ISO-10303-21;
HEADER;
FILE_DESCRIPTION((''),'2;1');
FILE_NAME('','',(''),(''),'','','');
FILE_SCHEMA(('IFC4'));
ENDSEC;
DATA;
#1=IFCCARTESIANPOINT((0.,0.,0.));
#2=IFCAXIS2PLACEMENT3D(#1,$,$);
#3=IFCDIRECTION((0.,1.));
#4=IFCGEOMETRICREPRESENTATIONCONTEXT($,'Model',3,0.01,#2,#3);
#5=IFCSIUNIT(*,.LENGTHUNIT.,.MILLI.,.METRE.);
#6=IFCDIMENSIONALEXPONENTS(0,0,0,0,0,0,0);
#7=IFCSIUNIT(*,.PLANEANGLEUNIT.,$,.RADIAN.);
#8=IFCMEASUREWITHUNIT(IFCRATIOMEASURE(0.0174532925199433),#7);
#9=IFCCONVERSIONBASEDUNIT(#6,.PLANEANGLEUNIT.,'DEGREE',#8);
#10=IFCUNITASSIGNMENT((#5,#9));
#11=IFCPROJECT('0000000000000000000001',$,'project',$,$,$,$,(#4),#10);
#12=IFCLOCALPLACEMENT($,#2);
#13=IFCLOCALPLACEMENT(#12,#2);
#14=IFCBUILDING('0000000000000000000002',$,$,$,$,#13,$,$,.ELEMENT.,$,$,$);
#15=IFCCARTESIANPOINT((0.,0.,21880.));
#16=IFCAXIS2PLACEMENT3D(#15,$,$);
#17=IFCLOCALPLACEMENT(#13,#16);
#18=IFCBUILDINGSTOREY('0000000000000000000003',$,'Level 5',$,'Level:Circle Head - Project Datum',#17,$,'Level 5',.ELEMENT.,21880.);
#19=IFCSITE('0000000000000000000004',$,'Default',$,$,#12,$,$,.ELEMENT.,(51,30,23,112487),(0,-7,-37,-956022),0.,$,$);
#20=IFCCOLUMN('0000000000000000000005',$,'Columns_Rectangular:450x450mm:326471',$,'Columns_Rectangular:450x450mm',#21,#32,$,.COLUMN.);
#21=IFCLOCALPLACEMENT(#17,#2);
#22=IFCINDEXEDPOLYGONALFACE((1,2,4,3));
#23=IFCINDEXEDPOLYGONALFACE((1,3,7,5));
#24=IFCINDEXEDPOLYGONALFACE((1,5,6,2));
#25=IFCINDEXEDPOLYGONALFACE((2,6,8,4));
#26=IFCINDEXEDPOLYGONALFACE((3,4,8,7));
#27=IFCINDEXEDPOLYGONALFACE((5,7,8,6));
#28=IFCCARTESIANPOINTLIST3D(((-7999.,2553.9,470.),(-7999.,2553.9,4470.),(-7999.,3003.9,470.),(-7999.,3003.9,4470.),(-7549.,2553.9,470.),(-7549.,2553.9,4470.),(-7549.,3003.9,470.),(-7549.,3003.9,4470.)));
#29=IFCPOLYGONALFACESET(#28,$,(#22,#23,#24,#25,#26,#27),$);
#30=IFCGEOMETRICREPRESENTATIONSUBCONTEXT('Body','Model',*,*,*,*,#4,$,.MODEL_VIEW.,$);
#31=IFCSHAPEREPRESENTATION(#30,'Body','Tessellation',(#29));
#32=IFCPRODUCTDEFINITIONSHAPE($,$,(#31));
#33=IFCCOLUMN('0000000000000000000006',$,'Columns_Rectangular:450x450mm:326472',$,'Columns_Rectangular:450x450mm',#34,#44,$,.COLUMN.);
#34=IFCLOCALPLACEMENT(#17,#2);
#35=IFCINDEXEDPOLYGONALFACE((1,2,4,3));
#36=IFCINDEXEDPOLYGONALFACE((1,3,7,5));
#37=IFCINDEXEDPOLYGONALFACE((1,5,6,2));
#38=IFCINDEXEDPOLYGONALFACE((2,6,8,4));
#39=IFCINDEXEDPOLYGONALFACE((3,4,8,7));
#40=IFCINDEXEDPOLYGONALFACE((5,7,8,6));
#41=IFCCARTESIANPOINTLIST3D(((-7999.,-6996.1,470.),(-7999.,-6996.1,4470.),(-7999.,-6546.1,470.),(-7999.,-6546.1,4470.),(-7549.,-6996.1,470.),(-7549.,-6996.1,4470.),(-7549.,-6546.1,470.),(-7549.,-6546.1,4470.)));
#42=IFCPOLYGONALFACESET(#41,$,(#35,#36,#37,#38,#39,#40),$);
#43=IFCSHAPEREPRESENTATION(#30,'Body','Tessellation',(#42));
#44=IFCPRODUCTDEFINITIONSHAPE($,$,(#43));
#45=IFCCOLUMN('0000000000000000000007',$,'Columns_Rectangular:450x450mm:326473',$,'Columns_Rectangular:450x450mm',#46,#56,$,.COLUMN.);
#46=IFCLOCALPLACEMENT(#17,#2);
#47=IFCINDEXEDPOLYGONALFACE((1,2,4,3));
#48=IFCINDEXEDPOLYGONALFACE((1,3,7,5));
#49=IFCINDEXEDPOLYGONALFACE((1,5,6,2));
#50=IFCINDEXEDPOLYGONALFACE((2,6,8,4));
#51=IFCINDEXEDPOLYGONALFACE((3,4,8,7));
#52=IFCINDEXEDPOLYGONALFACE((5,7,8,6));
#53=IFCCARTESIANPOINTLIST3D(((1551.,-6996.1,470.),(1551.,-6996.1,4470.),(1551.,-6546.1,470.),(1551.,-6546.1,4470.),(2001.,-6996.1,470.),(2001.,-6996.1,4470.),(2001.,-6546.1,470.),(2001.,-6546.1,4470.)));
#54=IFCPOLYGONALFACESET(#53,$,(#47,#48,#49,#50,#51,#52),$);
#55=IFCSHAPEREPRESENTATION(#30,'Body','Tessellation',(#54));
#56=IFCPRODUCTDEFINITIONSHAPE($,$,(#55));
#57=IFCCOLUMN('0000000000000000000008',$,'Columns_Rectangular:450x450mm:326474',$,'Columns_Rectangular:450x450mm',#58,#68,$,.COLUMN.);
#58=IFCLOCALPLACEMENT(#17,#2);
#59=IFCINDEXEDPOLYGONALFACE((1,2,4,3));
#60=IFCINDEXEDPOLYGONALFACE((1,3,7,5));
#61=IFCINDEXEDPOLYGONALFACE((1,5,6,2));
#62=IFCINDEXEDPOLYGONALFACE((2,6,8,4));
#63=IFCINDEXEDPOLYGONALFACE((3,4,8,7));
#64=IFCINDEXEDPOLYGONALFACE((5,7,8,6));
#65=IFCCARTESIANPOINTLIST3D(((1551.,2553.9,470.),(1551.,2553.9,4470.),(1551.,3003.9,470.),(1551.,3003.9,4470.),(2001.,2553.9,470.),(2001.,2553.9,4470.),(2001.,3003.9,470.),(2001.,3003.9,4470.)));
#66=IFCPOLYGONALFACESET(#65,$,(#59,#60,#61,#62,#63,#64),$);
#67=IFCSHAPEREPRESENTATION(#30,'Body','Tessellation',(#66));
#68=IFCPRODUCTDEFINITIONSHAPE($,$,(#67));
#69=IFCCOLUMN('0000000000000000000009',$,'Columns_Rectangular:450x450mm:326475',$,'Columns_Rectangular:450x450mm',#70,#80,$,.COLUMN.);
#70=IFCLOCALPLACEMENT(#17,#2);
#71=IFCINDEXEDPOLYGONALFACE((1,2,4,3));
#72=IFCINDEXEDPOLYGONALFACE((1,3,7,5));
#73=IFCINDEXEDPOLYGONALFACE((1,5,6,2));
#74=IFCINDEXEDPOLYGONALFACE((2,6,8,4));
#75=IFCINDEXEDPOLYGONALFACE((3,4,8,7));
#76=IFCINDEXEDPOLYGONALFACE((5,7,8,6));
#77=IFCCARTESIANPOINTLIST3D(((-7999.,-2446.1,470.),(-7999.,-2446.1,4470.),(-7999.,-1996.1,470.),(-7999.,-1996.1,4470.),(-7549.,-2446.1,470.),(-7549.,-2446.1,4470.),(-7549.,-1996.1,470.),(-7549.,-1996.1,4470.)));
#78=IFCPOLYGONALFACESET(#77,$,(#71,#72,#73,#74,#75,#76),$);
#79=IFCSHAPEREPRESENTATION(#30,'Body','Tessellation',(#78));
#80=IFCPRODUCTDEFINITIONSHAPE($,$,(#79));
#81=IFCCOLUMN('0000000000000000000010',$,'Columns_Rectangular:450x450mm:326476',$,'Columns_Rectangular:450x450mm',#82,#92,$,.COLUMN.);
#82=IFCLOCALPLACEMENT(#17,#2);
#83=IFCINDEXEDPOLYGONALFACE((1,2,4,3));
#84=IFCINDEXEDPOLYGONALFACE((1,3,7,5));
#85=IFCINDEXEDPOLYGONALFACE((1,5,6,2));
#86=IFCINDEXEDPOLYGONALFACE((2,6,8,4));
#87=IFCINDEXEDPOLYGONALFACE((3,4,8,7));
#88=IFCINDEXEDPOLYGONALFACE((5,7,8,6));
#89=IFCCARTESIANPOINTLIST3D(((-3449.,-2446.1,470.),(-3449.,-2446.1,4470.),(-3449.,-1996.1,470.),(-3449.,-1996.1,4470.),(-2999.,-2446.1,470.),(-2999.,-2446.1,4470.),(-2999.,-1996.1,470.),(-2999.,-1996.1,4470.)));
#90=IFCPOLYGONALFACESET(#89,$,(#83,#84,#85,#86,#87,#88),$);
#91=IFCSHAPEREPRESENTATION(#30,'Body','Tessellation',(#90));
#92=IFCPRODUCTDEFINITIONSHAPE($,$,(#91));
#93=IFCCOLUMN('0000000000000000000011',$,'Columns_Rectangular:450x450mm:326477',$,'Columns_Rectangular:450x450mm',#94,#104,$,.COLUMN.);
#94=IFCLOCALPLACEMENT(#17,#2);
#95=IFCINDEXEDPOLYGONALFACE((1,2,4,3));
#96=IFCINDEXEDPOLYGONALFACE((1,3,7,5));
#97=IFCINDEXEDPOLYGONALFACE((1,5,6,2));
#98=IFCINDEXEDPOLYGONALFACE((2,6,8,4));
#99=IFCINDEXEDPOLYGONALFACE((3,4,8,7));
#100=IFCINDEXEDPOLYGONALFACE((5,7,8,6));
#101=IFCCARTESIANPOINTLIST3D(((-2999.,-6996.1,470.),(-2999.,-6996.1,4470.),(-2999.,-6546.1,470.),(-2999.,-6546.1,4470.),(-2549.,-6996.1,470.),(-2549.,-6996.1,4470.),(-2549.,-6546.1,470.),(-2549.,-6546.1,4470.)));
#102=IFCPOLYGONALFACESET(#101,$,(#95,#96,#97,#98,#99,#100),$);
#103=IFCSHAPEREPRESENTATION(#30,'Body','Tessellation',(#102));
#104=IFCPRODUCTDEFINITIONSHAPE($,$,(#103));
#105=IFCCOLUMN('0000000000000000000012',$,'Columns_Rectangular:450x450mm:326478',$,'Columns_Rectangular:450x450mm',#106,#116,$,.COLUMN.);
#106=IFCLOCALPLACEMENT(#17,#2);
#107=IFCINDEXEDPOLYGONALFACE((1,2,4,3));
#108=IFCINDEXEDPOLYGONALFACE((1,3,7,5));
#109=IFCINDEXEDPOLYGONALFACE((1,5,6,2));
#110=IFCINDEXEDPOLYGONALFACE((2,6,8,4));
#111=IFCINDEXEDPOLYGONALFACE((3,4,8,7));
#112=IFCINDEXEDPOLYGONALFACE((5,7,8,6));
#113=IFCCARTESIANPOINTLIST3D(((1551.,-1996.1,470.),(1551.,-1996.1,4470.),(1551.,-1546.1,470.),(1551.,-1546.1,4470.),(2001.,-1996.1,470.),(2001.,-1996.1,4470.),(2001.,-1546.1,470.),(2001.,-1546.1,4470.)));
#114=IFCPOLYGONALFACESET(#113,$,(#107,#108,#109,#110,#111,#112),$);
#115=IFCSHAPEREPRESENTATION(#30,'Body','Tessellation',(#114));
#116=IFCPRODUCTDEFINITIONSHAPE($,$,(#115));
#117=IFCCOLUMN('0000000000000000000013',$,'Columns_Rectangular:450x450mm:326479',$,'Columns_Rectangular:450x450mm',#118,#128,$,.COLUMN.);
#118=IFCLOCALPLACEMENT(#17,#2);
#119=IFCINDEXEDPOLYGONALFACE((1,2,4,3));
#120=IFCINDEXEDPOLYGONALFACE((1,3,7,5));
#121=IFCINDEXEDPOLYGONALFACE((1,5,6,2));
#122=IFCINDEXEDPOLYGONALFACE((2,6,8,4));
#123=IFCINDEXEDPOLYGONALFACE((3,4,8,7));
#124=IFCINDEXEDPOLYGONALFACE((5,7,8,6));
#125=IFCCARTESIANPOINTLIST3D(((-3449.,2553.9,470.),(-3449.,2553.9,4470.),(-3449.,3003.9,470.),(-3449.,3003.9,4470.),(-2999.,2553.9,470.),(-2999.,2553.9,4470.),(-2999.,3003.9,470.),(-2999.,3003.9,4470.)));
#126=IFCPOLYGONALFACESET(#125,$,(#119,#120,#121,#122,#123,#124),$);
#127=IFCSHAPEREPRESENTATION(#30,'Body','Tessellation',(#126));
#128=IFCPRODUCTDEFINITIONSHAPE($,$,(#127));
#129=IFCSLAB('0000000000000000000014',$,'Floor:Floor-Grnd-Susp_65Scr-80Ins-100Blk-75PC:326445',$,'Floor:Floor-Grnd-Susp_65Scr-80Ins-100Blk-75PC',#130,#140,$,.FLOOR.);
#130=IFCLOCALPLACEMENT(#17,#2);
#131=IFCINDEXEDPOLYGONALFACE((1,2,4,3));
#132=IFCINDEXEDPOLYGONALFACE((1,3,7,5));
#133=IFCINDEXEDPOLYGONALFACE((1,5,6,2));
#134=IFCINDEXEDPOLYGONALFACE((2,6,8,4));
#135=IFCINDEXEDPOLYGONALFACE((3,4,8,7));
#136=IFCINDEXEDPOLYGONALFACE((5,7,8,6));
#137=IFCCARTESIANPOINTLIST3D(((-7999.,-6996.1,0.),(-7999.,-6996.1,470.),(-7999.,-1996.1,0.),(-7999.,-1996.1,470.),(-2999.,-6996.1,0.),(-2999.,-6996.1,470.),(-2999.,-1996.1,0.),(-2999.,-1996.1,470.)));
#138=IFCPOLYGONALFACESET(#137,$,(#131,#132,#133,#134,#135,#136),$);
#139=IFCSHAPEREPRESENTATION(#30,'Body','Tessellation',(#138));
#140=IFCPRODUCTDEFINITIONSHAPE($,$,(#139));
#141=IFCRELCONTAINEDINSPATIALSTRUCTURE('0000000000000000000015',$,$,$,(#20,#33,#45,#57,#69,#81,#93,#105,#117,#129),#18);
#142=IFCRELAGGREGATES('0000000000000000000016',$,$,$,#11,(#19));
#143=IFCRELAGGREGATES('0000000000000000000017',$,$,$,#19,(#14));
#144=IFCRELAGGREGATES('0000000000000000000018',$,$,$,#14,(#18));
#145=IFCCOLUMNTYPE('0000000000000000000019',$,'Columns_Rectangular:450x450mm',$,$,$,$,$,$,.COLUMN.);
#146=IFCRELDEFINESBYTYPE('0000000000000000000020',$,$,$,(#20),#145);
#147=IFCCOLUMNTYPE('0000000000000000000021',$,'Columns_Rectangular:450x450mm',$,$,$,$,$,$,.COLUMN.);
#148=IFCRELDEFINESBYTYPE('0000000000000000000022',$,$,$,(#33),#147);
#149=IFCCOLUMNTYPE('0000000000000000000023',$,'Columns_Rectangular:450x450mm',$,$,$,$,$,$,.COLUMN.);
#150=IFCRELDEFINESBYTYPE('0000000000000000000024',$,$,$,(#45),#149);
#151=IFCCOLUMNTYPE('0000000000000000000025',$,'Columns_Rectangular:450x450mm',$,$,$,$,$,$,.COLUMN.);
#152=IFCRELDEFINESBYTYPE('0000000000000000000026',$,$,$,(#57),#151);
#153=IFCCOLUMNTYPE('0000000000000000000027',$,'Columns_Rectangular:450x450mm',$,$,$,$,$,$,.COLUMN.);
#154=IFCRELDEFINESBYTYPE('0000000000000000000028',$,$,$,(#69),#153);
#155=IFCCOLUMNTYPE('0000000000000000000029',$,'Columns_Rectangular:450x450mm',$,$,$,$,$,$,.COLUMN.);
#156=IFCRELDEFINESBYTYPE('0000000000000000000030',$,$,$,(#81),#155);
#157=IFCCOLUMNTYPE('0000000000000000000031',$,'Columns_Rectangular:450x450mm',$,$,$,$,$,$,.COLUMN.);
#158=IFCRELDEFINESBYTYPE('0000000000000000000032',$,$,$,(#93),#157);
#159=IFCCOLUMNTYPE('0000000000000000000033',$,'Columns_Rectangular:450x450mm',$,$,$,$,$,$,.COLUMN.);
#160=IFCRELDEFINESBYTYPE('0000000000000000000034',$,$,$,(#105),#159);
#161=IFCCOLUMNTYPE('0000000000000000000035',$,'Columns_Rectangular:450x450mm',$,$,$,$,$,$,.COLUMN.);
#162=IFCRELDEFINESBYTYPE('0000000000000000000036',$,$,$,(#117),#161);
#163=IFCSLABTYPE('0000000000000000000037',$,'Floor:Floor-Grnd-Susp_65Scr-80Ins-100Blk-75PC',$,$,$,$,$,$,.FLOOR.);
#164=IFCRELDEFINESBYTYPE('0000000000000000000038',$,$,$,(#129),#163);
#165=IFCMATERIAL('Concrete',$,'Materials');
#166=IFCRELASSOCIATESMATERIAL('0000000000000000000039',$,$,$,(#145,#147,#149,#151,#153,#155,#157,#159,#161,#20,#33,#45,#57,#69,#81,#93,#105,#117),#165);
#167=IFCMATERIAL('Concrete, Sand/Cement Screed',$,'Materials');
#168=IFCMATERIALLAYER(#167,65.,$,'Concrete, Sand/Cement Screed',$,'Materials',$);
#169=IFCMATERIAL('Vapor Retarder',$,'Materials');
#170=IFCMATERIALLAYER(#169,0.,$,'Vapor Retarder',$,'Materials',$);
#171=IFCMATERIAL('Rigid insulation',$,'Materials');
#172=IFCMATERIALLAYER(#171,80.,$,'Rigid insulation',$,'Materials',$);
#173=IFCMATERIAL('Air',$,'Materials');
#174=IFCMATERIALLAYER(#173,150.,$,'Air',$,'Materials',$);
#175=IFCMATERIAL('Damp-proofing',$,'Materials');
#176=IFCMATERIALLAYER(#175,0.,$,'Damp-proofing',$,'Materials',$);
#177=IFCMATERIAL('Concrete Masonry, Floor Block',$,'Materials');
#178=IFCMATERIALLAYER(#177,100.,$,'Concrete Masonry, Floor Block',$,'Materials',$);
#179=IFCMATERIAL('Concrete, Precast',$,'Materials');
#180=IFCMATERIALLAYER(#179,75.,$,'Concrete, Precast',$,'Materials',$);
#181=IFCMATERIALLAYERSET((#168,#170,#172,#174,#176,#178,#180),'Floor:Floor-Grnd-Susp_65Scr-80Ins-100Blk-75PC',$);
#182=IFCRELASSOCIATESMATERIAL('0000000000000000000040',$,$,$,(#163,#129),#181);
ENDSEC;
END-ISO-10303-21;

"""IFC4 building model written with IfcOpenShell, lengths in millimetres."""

from ifc_helpers import new_model, entity, si_unit, converted_unit, direction, frame, frame_2d, origin, origin_2d_with_axis, place, context, subcontext, project, spatial, polyline, segment, composite_curve, rectangle, outline, extrude, source, transform, mapped, material, layer, layer_set, layer_usage, material_profile, profile_set, profile_usage, type_object, type_shapes, element, save


model = new_model("IFC4")

# Units and contexts
model_context = context("Model", 3, precision=0.01, world=origin(), true_north=direction((0.0, 1.0)))
body_context = subcontext(model_context, "Body", "Model", "MODEL_VIEW")
ifc_project = project(units=[si_unit("LENGTHUNIT", "METRE", prefix="MILLI"), converted_unit("PLANEANGLEUNIT", "DEGREE", entity("IfcRatioMeasure", 0.0174532925199433), si_unit("PLANEANGLEUNIT", "RADIAN"), dimensions=[0, 0, 0, 0, 0, 0, 0])], contexts=[model_context])

# Site, building, storey
site_placement = place(None, origin())
site = spatial("IfcSite", under=ifc_project, at=site_placement, Name="Default", CompositionType="ELEMENT", RefLatitude=(51, 30, 23, 112487), RefLongitude=(0, -7, -37, -956022), RefElevation=0.0)
building_placement = place(site_placement, origin())
building = spatial("IfcBuilding", under=site, at=building_placement, CompositionType="ELEMENT")
storey_placement = place(building_placement, frame((0.0, 0.0, 21880.0)))
storey = spatial("IfcBuildingStorey", under=building, at=storey_placement, Name="Level 5", ObjectType="Level:Circle Head - Project Datum", LongName="Level 5", CompositionType="ELEMENT", Elevation=21880.0)

# Columns
ifc_material_1 = material(Name="Concrete", Category="Materials")
ifc_material_profile = material_profile(ifc_material_1, outline(composite_curve([segment(polyline([(225.0, 225.0, 0.0), (225.0, -225.0, 0.0)]), True, "CONTINUOUS"), segment(polyline([(225.0, -225.0, 0.0), (-225.0, -225.0, 0.0)]), True, "CONTINUOUS"), segment(polyline([(-225.0, -225.0, 0.0), (-225.0, 225.0, 0.0)]), True, "CONTINUOUS"), segment(polyline([(-225.0, 225.0, 0.0), (225.0, 225.0, 0.0)]), True, "CONTINUOUS")], self_intersect=False), kind="CURVE"), Name="450x450mm")
ifc_profile_set = profile_set([ifc_material_profile], Name="450x450mm")
ifc_profile_usage_1 = profile_usage(ifc_profile_set)
column_type_1 = type_object("IfcColumnType", Name="Columns_Rectangular:450x450mm", PredefinedType="COLUMN", material=ifc_profile_set)
shared_shape_1 = source(origin(), body_context, "Body", "SweptSolid", [
    extrude(rectangle(XDim=450.0, YDim=450.0, at=frame_2d((0.0, 0.0), x_axis=(1.0, 0.0))), frame((-7774.0, 2778.9, 22350.0), z_axis=(0.0, 0.0, 1.0), x_axis=(0.0, -1.0, 0.0)), (0.0, 0.0, 1.0), 4000.0),
])
type_shapes(column_type_1, [shared_shape_1])
column_1_placement = place(storey_placement, frame((0.0, 0.0, -21880.0)))
element("IfcColumn", 1, at=column_1_placement, inside=storey, type_object=column_type_1, material=ifc_profile_usage_1, Name="Columns_Rectangular:450x450mm:326471", ObjectType="Columns_Rectangular:450x450mm", PredefinedType="COLUMN", context=body_context, shape_type="MappedRepresentation", body=[
    mapped(shared_shape_1, transform((0.0, 0.0, 0.0), scale=1.0)),
])
ifc_profile_usage_2 = profile_usage(ifc_profile_set)
column_type_2 = type_object("IfcColumnType", Name="Columns_Rectangular:450x450mm", PredefinedType="COLUMN", material=ifc_profile_set)
shared_shape_2 = source(origin(), body_context, "Body", "SweptSolid", [
    extrude(rectangle(XDim=450.0, YDim=450.0, at=frame_2d((0.0, 0.0), x_axis=(1.0, 0.0))), frame((-7774.0, -6771.1, 22350.0), z_axis=(0.0, 0.0, 1.0), x_axis=(0.0, -1.0, 0.0)), (0.0, 0.0, 1.0), 4000.0),
])
type_shapes(column_type_2, [shared_shape_2])
column_2_placement = place(storey_placement, frame((0.0, 0.0, -21880.0)))
element("IfcColumn", 2, at=column_2_placement, inside=storey, type_object=column_type_2, material=ifc_profile_usage_2, Name="Columns_Rectangular:450x450mm:326472", ObjectType="Columns_Rectangular:450x450mm", PredefinedType="COLUMN", context=body_context, shape_type="MappedRepresentation", body=[
    mapped(shared_shape_2, transform((0.0, 0.0, 0.0), scale=1.0)),
])
ifc_profile_usage_3 = profile_usage(ifc_profile_set)
column_type_3 = type_object("IfcColumnType", Name="Columns_Rectangular:450x450mm", PredefinedType="COLUMN", material=ifc_profile_set)
shared_shape_3 = source(origin(), body_context, "Body", "SweptSolid", [
    extrude(rectangle(XDim=450.0, YDim=450.0, at=frame_2d((0.0, 0.0), x_axis=(1.0, 0.0))), frame((1776.0, -6771.1, 22350.0), z_axis=(0.0, 0.0, 1.0), x_axis=(0.0, -1.0, 0.0)), (0.0, 0.0, 1.0), 4000.0),
])
type_shapes(column_type_3, [shared_shape_3])
column_3_placement = place(storey_placement, frame((0.0, 0.0, -21880.0)))
element("IfcColumn", 3, at=column_3_placement, inside=storey, type_object=column_type_3, material=ifc_profile_usage_3, Name="Columns_Rectangular:450x450mm:326473", ObjectType="Columns_Rectangular:450x450mm", PredefinedType="COLUMN", context=body_context, shape_type="MappedRepresentation", body=[
    mapped(shared_shape_3, transform((0.0, 0.0, 0.0), scale=1.0)),
])
ifc_profile_usage_4 = profile_usage(ifc_profile_set)
column_type_4 = type_object("IfcColumnType", Name="Columns_Rectangular:450x450mm", PredefinedType="COLUMN", material=ifc_profile_set)
shared_shape_4 = source(origin(), body_context, "Body", "SweptSolid", [
    extrude(rectangle(XDim=450.0, YDim=450.0, at=frame_2d((0.0, 0.0), x_axis=(1.0, 0.0))), frame((1776.0, 2778.9, 22350.0), z_axis=(0.0, 0.0, 1.0), x_axis=(0.0, -1.0, 0.0)), (0.0, 0.0, 1.0), 4000.0),
])
type_shapes(column_type_4, [shared_shape_4])
column_4_placement = place(storey_placement, frame((0.0, 0.0, -21880.0)))
element("IfcColumn", 4, at=column_4_placement, inside=storey, type_object=column_type_4, material=ifc_profile_usage_4, Name="Columns_Rectangular:450x450mm:326474", ObjectType="Columns_Rectangular:450x450mm", PredefinedType="COLUMN", context=body_context, shape_type="MappedRepresentation", body=[
    mapped(shared_shape_4, transform((0.0, 0.0, 0.0), scale=1.0)),
])
ifc_profile_usage_5 = profile_usage(ifc_profile_set)
column_type_5 = type_object("IfcColumnType", Name="Columns_Rectangular:450x450mm", PredefinedType="COLUMN", material=ifc_profile_set)
shared_shape_5 = source(origin(), body_context, "Body", "SweptSolid", [
    extrude(rectangle(XDim=450.0, YDim=450.0, at=frame_2d((0.0, 0.0), x_axis=(1.0, 0.0))), frame((-7774.0, -2221.1, 22350.0), z_axis=(0.0, 0.0, 1.0), x_axis=(0.0, -1.0, 0.0)), (0.0, 0.0, 1.0), 4000.0),
])
type_shapes(column_type_5, [shared_shape_5])
column_5_placement = place(storey_placement, frame((0.0, 0.0, -21880.0)))
element("IfcColumn", 5, at=column_5_placement, inside=storey, type_object=column_type_5, material=ifc_profile_usage_5, Name="Columns_Rectangular:450x450mm:326475", ObjectType="Columns_Rectangular:450x450mm", PredefinedType="COLUMN", context=body_context, shape_type="MappedRepresentation", body=[
    mapped(shared_shape_5, transform((0.0, 0.0, 0.0), scale=1.0)),
])
ifc_profile_usage_6 = profile_usage(ifc_profile_set)
column_type_6 = type_object("IfcColumnType", Name="Columns_Rectangular:450x450mm", PredefinedType="COLUMN", material=ifc_profile_set)
shared_shape_6 = source(origin(), body_context, "Body", "SweptSolid", [
    extrude(rectangle(XDim=450.0, YDim=450.0, at=origin_2d_with_axis()), frame((0.0, 0.0, 22350.0), z_axis=(0.0, 0.0, 1.0), x_axis=(0.0, -1.0, 0.0)), (0.0, 0.0, 1.0), 4000.0),
])
type_shapes(column_type_6, [shared_shape_6])
column_6_placement = place(storey_placement, frame((-3224.0, -2221.1, -21880.0)))
element("IfcColumn", 6, at=column_6_placement, inside=storey, type_object=column_type_6, material=ifc_profile_usage_6, Name="Columns_Rectangular:450x450mm:326476", ObjectType="Columns_Rectangular:450x450mm", PredefinedType="COLUMN", context=body_context, shape_type="MappedRepresentation", body=[
    mapped(shared_shape_6, transform((0.0, 0.0, 0.0), scale=1.0)),
])
ifc_profile_usage_7 = profile_usage(ifc_profile_set)
column_type_7 = type_object("IfcColumnType", Name="Columns_Rectangular:450x450mm", PredefinedType="COLUMN", material=ifc_profile_set)
shared_shape_7 = source(origin(), body_context, "Body", "SweptSolid", [
    extrude(rectangle(XDim=450.0, YDim=450.0, at=frame_2d((0.0, 0.0), x_axis=(1.0, 0.0))), frame((-2774.0, -6771.1, 22350.0), z_axis=(0.0, 0.0, 1.0), x_axis=(0.0, -1.0, 0.0)), (0.0, 0.0, 1.0), 4000.0),
])
type_shapes(column_type_7, [shared_shape_7])
column_7_placement = place(storey_placement, frame((0.0, 0.0, -21880.0)))
element("IfcColumn", 7, at=column_7_placement, inside=storey, type_object=column_type_7, material=ifc_profile_usage_7, Name="Columns_Rectangular:450x450mm:326477", ObjectType="Columns_Rectangular:450x450mm", PredefinedType="COLUMN", context=body_context, shape_type="MappedRepresentation", body=[
    mapped(shared_shape_7, transform((0.0, 0.0, 0.0), scale=1.0)),
])
ifc_profile_usage_8 = profile_usage(ifc_profile_set)
column_type_8 = type_object("IfcColumnType", Name="Columns_Rectangular:450x450mm", PredefinedType="COLUMN", material=ifc_profile_set)
shared_shape_8 = source(origin(), body_context, "Body", "SweptSolid", [
    extrude(rectangle(XDim=450.0, YDim=450.0, at=frame_2d((0.0, 0.0), x_axis=(1.0, 0.0))), frame((1776.0, -1771.1, 22350.0), z_axis=(0.0, 0.0, 1.0), x_axis=(0.0, -1.0, 0.0)), (0.0, 0.0, 1.0), 4000.0),
])
type_shapes(column_type_8, [shared_shape_8])
column_8_placement = place(storey_placement, frame((0.0, 0.0, -21880.0)))
element("IfcColumn", 8, at=column_8_placement, inside=storey, type_object=column_type_8, material=ifc_profile_usage_8, Name="Columns_Rectangular:450x450mm:326478", ObjectType="Columns_Rectangular:450x450mm", PredefinedType="COLUMN", context=body_context, shape_type="MappedRepresentation", body=[
    mapped(shared_shape_8, transform((0.0, 0.0, 0.0), scale=1.0)),
])
ifc_profile_usage_9 = profile_usage(ifc_profile_set)
column_type_9 = type_object("IfcColumnType", Name="Columns_Rectangular:450x450mm", PredefinedType="COLUMN", material=ifc_profile_set)
shared_shape_9 = source(origin(), body_context, "Body", "SweptSolid", [
    extrude(rectangle(XDim=450.0, YDim=450.0, at=frame_2d((0.0, 0.0), x_axis=(1.0, 0.0))), frame((-3224.0, 2778.9, 22350.0), z_axis=(0.0, 0.0, 1.0), x_axis=(0.0, -1.0, 0.0)), (0.0, 0.0, 1.0), 4000.0),
])
type_shapes(column_type_9, [shared_shape_9])
column_9_placement = place(storey_placement, frame((0.0, 0.0, -21880.0)))
element("IfcColumn", 9, at=column_9_placement, inside=storey, type_object=column_type_9, material=ifc_profile_usage_9, Name="Columns_Rectangular:450x450mm:326479", ObjectType="Columns_Rectangular:450x450mm", PredefinedType="COLUMN", context=body_context, shape_type="MappedRepresentation", body=[
    mapped(shared_shape_9, transform((0.0, 0.0, 0.0), scale=1.0)),
])

# Slab
ifc_material_2 = material(Name="Concrete, Sand/Cement Screed", Category="Materials")
ifc_layer_1 = layer(ifc_material_2, 65.0, Name="Concrete, Sand/Cement Screed", Category="Materials")
ifc_material_3 = material(Name="Vapor Retarder", Category="Materials")
ifc_layer_2 = layer(ifc_material_3, 0.0, Name="Vapor Retarder", Category="Materials")
ifc_material_4 = material(Name="Rigid insulation", Category="Materials")
ifc_layer_3 = layer(ifc_material_4, 80.0, Name="Rigid insulation", Category="Materials")
ifc_material_5 = material(Name="Air", Category="Materials")
ifc_layer_4 = layer(ifc_material_5, 150.0, Name="Air", Category="Materials")
ifc_material_6 = material(Name="Damp-proofing", Category="Materials")
ifc_layer_5 = layer(ifc_material_6, 0.0, Name="Damp-proofing", Category="Materials")
ifc_material_7 = material(Name="Concrete Masonry, Floor Block", Category="Materials")
ifc_layer_6 = layer(ifc_material_7, 100.0, Name="Concrete Masonry, Floor Block", Category="Materials")
ifc_material_8 = material(Name="Concrete, Precast", Category="Materials")
ifc_layer_7 = layer(ifc_material_8, 75.0, Name="Concrete, Precast", Category="Materials")
ifc_layer_set_1 = layer_set([ifc_layer_1, ifc_layer_2, ifc_layer_3, ifc_layer_4, ifc_layer_5, ifc_layer_6, ifc_layer_7], Name="Floor:Floor-Grnd-Susp_65Scr-80Ins-100Blk-75PC")
ifc_layer_usage_1 = layer_usage(ifc_layer_set_1, "AXIS3", "POSITIVE", 0.0)
slab_type_1 = type_object("IfcSlabType", Name="Floor:Floor-Grnd-Susp_65Scr-80Ins-100Blk-75PC", PredefinedType="FLOOR", material=ifc_layer_set_1)
slab_1_placement = place(storey_placement, origin())
element("IfcSlab", 10, at=slab_1_placement, inside=storey, type_object=slab_type_1, material=ifc_layer_usage_1, Name="Floor:Floor-Grnd-Susp_65Scr-80Ins-100Blk-75PC:326445", ObjectType="Floor:Floor-Grnd-Susp_65Scr-80Ins-100Blk-75PC", PredefinedType="FLOOR", context=body_context, shape_type="SweptSolid", body=[
    extrude(rectangle(XDim=5000.0, YDim=5000.0, at=frame_2d((0.0, 0.0), x_axis=(1.0, 0.0))), frame((-5499.0, -4496.1, 470.0), z_axis=(0.0, 0.0, -1.0), x_axis=(0.0, 1.0, 0.0)), (0.0, 0.0, 1.0), 470.0),
])

save(model, "model.ifc")
